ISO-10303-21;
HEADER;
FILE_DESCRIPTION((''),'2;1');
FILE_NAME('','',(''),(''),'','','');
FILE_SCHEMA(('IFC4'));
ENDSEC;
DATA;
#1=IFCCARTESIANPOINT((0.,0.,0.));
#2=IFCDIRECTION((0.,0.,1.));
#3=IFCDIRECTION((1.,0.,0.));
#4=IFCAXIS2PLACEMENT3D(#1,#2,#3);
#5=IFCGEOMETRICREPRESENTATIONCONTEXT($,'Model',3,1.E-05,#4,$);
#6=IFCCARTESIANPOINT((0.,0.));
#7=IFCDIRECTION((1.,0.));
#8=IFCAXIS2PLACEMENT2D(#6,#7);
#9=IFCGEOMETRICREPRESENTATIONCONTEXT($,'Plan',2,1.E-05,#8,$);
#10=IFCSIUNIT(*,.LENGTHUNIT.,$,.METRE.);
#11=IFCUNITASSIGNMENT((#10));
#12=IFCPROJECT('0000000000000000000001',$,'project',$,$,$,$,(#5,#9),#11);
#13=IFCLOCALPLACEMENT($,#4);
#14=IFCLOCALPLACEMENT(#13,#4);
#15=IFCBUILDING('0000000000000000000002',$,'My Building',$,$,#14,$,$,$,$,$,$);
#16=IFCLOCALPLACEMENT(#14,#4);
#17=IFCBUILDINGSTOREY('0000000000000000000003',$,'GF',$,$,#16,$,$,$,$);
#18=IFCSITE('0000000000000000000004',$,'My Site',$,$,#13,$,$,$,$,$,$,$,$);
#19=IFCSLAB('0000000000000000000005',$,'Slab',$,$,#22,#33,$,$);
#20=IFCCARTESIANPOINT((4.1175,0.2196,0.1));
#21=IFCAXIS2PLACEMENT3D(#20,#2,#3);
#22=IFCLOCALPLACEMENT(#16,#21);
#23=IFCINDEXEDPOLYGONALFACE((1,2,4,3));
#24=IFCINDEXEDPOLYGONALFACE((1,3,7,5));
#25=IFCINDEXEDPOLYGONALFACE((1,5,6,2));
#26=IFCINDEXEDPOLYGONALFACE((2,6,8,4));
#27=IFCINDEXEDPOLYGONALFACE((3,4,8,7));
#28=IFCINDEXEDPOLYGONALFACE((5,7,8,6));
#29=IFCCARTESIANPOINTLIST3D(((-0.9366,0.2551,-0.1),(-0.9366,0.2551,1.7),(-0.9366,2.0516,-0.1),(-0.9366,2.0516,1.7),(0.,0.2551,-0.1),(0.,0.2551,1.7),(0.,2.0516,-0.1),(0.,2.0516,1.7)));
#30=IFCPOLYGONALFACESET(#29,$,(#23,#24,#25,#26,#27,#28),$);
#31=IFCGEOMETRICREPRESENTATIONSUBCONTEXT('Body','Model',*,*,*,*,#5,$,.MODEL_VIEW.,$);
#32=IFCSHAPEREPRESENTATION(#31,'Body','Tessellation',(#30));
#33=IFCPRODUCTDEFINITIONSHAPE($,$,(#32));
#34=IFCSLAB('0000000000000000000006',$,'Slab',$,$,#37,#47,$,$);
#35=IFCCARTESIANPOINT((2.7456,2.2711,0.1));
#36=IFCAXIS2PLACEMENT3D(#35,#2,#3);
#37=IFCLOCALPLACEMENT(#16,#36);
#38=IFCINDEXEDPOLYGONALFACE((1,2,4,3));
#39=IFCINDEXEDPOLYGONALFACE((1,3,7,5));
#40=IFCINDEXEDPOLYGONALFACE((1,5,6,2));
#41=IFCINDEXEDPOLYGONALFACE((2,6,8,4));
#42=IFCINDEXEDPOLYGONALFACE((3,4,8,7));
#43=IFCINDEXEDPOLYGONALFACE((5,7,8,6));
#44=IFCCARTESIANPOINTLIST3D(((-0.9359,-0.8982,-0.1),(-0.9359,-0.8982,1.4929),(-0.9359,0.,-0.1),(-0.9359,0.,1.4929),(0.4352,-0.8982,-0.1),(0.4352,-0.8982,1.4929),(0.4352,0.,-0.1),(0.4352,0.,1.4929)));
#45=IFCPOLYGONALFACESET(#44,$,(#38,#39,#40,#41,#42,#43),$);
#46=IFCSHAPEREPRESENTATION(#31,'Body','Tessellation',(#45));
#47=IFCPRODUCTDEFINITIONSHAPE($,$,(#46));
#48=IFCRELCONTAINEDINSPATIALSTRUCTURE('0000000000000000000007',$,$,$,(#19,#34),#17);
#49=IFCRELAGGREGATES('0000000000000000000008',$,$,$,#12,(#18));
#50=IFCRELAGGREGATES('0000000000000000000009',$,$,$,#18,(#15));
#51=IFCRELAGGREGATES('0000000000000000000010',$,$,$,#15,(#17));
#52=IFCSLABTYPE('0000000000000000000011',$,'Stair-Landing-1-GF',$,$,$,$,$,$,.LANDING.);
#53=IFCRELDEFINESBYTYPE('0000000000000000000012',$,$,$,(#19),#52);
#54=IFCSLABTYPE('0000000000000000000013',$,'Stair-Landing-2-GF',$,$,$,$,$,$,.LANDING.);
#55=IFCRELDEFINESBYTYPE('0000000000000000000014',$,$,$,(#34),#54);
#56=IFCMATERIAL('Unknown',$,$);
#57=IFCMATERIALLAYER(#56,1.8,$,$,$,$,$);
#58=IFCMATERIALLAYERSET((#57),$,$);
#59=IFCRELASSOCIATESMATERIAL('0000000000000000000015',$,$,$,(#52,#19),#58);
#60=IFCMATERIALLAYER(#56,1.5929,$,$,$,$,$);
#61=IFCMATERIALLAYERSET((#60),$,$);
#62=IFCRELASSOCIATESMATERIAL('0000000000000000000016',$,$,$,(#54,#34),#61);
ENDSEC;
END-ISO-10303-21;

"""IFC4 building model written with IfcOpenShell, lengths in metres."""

from ifc_helpers import new_model, si_unit, frame, origin_with_axes, origin_2d_with_axis, place, context, subcontext, project, spatial, indexed_curve, outline, extrude, material, layer, layer_set, layer_usage, type_object, element, save


model = new_model("IFC4")

# Units and contexts
model_context = context("Model", 3, precision=1e-05, world=origin_with_axes())
plan_context = context("Plan", 2, precision=1e-05, world=origin_2d_with_axis())
body_context_1 = subcontext(model_context, "Body", "Model", "MODEL_VIEW")
ifc_project = project(units=[si_unit("LENGTHUNIT", "METRE")], contexts=[model_context, plan_context])

# Site, building, storey
site_placement = place(None, origin_with_axes())
site = spatial("IfcSite", under=ifc_project, at=site_placement, Name="My Site")
building_placement = place(site_placement, origin_with_axes())
building = spatial("IfcBuilding", under=site, at=building_placement, Name="My Building")
storey_placement = place(building_placement, origin_with_axes())
storey = spatial("IfcBuildingStorey", under=building, at=storey_placement, Name="GF")

# Slabs
ifc_material = material(Name="Unknown")
ifc_layer_1 = layer(ifc_material, 1.8)
ifc_layer_set_1 = layer_set([ifc_layer_1])
ifc_layer_usage_1 = layer_usage(ifc_layer_set_1, "AXIS3", "POSITIVE", -0.1)
slab_type_1 = type_object("IfcSlabType", Name="Stair-Landing-1-GF", PredefinedType="LANDING", material=ifc_layer_set_1)
slab_1_placement = place(storey_placement, frame((4.1175, 0.2196, 0.1), z_axis=(0.0, 0.0, 1.0), x_axis=(1.0, 0.0, 0.0)))
element("IfcSlab", 1, at=slab_1_placement, inside=storey, type_object=slab_type_1, material=ifc_layer_usage_1, Name="Slab", context=body_context_1, shape_type="SweptSolid", body=[
    extrude(outline(indexed_curve([(0.0, 0.2551), (0.0, 2.0516), (-0.9366, 2.0516), (-0.9366, 0.2551), (0.0, 0.2551)])), frame((0.0, 0.0, -0.1), z_axis=(0.0, 0.0, 1.0), x_axis=(1.0, 0.0, 0.0)), (0.0, 0.0, 1.0), 1.8),
])
ifc_layer_2 = layer(ifc_material, 1.5929)
ifc_layer_set_2 = layer_set([ifc_layer_2])
ifc_layer_usage_2 = layer_usage(ifc_layer_set_2, "AXIS3", "POSITIVE", -0.1)
slab_type_2 = type_object("IfcSlabType", Name="Stair-Landing-2-GF", PredefinedType="LANDING", material=ifc_layer_set_2)
slab_2_placement = place(storey_placement, frame((2.7456, 2.2711, 0.1), z_axis=(0.0, 0.0, 1.0), x_axis=(1.0, 0.0, 0.0)))
element("IfcSlab", 2, at=slab_2_placement, inside=storey, type_object=slab_type_2, material=ifc_layer_usage_2, Name="Slab", context=body_context_1, shape_type="SweptSolid", body=[
    extrude(outline(indexed_curve([(0.4352, 0.0), (0.4352, -0.8982), (-0.9359, -0.8982), (-0.9359, 0.0), (0.4352, 0.0)])), frame((0.0, 0.0, -0.1), z_axis=(0.0, 0.0, 1.0), x_axis=(1.0, 0.0, 0.0)), (0.0, 0.0, 1.0), 1.5929),
])

save(model, "model.ifc")
